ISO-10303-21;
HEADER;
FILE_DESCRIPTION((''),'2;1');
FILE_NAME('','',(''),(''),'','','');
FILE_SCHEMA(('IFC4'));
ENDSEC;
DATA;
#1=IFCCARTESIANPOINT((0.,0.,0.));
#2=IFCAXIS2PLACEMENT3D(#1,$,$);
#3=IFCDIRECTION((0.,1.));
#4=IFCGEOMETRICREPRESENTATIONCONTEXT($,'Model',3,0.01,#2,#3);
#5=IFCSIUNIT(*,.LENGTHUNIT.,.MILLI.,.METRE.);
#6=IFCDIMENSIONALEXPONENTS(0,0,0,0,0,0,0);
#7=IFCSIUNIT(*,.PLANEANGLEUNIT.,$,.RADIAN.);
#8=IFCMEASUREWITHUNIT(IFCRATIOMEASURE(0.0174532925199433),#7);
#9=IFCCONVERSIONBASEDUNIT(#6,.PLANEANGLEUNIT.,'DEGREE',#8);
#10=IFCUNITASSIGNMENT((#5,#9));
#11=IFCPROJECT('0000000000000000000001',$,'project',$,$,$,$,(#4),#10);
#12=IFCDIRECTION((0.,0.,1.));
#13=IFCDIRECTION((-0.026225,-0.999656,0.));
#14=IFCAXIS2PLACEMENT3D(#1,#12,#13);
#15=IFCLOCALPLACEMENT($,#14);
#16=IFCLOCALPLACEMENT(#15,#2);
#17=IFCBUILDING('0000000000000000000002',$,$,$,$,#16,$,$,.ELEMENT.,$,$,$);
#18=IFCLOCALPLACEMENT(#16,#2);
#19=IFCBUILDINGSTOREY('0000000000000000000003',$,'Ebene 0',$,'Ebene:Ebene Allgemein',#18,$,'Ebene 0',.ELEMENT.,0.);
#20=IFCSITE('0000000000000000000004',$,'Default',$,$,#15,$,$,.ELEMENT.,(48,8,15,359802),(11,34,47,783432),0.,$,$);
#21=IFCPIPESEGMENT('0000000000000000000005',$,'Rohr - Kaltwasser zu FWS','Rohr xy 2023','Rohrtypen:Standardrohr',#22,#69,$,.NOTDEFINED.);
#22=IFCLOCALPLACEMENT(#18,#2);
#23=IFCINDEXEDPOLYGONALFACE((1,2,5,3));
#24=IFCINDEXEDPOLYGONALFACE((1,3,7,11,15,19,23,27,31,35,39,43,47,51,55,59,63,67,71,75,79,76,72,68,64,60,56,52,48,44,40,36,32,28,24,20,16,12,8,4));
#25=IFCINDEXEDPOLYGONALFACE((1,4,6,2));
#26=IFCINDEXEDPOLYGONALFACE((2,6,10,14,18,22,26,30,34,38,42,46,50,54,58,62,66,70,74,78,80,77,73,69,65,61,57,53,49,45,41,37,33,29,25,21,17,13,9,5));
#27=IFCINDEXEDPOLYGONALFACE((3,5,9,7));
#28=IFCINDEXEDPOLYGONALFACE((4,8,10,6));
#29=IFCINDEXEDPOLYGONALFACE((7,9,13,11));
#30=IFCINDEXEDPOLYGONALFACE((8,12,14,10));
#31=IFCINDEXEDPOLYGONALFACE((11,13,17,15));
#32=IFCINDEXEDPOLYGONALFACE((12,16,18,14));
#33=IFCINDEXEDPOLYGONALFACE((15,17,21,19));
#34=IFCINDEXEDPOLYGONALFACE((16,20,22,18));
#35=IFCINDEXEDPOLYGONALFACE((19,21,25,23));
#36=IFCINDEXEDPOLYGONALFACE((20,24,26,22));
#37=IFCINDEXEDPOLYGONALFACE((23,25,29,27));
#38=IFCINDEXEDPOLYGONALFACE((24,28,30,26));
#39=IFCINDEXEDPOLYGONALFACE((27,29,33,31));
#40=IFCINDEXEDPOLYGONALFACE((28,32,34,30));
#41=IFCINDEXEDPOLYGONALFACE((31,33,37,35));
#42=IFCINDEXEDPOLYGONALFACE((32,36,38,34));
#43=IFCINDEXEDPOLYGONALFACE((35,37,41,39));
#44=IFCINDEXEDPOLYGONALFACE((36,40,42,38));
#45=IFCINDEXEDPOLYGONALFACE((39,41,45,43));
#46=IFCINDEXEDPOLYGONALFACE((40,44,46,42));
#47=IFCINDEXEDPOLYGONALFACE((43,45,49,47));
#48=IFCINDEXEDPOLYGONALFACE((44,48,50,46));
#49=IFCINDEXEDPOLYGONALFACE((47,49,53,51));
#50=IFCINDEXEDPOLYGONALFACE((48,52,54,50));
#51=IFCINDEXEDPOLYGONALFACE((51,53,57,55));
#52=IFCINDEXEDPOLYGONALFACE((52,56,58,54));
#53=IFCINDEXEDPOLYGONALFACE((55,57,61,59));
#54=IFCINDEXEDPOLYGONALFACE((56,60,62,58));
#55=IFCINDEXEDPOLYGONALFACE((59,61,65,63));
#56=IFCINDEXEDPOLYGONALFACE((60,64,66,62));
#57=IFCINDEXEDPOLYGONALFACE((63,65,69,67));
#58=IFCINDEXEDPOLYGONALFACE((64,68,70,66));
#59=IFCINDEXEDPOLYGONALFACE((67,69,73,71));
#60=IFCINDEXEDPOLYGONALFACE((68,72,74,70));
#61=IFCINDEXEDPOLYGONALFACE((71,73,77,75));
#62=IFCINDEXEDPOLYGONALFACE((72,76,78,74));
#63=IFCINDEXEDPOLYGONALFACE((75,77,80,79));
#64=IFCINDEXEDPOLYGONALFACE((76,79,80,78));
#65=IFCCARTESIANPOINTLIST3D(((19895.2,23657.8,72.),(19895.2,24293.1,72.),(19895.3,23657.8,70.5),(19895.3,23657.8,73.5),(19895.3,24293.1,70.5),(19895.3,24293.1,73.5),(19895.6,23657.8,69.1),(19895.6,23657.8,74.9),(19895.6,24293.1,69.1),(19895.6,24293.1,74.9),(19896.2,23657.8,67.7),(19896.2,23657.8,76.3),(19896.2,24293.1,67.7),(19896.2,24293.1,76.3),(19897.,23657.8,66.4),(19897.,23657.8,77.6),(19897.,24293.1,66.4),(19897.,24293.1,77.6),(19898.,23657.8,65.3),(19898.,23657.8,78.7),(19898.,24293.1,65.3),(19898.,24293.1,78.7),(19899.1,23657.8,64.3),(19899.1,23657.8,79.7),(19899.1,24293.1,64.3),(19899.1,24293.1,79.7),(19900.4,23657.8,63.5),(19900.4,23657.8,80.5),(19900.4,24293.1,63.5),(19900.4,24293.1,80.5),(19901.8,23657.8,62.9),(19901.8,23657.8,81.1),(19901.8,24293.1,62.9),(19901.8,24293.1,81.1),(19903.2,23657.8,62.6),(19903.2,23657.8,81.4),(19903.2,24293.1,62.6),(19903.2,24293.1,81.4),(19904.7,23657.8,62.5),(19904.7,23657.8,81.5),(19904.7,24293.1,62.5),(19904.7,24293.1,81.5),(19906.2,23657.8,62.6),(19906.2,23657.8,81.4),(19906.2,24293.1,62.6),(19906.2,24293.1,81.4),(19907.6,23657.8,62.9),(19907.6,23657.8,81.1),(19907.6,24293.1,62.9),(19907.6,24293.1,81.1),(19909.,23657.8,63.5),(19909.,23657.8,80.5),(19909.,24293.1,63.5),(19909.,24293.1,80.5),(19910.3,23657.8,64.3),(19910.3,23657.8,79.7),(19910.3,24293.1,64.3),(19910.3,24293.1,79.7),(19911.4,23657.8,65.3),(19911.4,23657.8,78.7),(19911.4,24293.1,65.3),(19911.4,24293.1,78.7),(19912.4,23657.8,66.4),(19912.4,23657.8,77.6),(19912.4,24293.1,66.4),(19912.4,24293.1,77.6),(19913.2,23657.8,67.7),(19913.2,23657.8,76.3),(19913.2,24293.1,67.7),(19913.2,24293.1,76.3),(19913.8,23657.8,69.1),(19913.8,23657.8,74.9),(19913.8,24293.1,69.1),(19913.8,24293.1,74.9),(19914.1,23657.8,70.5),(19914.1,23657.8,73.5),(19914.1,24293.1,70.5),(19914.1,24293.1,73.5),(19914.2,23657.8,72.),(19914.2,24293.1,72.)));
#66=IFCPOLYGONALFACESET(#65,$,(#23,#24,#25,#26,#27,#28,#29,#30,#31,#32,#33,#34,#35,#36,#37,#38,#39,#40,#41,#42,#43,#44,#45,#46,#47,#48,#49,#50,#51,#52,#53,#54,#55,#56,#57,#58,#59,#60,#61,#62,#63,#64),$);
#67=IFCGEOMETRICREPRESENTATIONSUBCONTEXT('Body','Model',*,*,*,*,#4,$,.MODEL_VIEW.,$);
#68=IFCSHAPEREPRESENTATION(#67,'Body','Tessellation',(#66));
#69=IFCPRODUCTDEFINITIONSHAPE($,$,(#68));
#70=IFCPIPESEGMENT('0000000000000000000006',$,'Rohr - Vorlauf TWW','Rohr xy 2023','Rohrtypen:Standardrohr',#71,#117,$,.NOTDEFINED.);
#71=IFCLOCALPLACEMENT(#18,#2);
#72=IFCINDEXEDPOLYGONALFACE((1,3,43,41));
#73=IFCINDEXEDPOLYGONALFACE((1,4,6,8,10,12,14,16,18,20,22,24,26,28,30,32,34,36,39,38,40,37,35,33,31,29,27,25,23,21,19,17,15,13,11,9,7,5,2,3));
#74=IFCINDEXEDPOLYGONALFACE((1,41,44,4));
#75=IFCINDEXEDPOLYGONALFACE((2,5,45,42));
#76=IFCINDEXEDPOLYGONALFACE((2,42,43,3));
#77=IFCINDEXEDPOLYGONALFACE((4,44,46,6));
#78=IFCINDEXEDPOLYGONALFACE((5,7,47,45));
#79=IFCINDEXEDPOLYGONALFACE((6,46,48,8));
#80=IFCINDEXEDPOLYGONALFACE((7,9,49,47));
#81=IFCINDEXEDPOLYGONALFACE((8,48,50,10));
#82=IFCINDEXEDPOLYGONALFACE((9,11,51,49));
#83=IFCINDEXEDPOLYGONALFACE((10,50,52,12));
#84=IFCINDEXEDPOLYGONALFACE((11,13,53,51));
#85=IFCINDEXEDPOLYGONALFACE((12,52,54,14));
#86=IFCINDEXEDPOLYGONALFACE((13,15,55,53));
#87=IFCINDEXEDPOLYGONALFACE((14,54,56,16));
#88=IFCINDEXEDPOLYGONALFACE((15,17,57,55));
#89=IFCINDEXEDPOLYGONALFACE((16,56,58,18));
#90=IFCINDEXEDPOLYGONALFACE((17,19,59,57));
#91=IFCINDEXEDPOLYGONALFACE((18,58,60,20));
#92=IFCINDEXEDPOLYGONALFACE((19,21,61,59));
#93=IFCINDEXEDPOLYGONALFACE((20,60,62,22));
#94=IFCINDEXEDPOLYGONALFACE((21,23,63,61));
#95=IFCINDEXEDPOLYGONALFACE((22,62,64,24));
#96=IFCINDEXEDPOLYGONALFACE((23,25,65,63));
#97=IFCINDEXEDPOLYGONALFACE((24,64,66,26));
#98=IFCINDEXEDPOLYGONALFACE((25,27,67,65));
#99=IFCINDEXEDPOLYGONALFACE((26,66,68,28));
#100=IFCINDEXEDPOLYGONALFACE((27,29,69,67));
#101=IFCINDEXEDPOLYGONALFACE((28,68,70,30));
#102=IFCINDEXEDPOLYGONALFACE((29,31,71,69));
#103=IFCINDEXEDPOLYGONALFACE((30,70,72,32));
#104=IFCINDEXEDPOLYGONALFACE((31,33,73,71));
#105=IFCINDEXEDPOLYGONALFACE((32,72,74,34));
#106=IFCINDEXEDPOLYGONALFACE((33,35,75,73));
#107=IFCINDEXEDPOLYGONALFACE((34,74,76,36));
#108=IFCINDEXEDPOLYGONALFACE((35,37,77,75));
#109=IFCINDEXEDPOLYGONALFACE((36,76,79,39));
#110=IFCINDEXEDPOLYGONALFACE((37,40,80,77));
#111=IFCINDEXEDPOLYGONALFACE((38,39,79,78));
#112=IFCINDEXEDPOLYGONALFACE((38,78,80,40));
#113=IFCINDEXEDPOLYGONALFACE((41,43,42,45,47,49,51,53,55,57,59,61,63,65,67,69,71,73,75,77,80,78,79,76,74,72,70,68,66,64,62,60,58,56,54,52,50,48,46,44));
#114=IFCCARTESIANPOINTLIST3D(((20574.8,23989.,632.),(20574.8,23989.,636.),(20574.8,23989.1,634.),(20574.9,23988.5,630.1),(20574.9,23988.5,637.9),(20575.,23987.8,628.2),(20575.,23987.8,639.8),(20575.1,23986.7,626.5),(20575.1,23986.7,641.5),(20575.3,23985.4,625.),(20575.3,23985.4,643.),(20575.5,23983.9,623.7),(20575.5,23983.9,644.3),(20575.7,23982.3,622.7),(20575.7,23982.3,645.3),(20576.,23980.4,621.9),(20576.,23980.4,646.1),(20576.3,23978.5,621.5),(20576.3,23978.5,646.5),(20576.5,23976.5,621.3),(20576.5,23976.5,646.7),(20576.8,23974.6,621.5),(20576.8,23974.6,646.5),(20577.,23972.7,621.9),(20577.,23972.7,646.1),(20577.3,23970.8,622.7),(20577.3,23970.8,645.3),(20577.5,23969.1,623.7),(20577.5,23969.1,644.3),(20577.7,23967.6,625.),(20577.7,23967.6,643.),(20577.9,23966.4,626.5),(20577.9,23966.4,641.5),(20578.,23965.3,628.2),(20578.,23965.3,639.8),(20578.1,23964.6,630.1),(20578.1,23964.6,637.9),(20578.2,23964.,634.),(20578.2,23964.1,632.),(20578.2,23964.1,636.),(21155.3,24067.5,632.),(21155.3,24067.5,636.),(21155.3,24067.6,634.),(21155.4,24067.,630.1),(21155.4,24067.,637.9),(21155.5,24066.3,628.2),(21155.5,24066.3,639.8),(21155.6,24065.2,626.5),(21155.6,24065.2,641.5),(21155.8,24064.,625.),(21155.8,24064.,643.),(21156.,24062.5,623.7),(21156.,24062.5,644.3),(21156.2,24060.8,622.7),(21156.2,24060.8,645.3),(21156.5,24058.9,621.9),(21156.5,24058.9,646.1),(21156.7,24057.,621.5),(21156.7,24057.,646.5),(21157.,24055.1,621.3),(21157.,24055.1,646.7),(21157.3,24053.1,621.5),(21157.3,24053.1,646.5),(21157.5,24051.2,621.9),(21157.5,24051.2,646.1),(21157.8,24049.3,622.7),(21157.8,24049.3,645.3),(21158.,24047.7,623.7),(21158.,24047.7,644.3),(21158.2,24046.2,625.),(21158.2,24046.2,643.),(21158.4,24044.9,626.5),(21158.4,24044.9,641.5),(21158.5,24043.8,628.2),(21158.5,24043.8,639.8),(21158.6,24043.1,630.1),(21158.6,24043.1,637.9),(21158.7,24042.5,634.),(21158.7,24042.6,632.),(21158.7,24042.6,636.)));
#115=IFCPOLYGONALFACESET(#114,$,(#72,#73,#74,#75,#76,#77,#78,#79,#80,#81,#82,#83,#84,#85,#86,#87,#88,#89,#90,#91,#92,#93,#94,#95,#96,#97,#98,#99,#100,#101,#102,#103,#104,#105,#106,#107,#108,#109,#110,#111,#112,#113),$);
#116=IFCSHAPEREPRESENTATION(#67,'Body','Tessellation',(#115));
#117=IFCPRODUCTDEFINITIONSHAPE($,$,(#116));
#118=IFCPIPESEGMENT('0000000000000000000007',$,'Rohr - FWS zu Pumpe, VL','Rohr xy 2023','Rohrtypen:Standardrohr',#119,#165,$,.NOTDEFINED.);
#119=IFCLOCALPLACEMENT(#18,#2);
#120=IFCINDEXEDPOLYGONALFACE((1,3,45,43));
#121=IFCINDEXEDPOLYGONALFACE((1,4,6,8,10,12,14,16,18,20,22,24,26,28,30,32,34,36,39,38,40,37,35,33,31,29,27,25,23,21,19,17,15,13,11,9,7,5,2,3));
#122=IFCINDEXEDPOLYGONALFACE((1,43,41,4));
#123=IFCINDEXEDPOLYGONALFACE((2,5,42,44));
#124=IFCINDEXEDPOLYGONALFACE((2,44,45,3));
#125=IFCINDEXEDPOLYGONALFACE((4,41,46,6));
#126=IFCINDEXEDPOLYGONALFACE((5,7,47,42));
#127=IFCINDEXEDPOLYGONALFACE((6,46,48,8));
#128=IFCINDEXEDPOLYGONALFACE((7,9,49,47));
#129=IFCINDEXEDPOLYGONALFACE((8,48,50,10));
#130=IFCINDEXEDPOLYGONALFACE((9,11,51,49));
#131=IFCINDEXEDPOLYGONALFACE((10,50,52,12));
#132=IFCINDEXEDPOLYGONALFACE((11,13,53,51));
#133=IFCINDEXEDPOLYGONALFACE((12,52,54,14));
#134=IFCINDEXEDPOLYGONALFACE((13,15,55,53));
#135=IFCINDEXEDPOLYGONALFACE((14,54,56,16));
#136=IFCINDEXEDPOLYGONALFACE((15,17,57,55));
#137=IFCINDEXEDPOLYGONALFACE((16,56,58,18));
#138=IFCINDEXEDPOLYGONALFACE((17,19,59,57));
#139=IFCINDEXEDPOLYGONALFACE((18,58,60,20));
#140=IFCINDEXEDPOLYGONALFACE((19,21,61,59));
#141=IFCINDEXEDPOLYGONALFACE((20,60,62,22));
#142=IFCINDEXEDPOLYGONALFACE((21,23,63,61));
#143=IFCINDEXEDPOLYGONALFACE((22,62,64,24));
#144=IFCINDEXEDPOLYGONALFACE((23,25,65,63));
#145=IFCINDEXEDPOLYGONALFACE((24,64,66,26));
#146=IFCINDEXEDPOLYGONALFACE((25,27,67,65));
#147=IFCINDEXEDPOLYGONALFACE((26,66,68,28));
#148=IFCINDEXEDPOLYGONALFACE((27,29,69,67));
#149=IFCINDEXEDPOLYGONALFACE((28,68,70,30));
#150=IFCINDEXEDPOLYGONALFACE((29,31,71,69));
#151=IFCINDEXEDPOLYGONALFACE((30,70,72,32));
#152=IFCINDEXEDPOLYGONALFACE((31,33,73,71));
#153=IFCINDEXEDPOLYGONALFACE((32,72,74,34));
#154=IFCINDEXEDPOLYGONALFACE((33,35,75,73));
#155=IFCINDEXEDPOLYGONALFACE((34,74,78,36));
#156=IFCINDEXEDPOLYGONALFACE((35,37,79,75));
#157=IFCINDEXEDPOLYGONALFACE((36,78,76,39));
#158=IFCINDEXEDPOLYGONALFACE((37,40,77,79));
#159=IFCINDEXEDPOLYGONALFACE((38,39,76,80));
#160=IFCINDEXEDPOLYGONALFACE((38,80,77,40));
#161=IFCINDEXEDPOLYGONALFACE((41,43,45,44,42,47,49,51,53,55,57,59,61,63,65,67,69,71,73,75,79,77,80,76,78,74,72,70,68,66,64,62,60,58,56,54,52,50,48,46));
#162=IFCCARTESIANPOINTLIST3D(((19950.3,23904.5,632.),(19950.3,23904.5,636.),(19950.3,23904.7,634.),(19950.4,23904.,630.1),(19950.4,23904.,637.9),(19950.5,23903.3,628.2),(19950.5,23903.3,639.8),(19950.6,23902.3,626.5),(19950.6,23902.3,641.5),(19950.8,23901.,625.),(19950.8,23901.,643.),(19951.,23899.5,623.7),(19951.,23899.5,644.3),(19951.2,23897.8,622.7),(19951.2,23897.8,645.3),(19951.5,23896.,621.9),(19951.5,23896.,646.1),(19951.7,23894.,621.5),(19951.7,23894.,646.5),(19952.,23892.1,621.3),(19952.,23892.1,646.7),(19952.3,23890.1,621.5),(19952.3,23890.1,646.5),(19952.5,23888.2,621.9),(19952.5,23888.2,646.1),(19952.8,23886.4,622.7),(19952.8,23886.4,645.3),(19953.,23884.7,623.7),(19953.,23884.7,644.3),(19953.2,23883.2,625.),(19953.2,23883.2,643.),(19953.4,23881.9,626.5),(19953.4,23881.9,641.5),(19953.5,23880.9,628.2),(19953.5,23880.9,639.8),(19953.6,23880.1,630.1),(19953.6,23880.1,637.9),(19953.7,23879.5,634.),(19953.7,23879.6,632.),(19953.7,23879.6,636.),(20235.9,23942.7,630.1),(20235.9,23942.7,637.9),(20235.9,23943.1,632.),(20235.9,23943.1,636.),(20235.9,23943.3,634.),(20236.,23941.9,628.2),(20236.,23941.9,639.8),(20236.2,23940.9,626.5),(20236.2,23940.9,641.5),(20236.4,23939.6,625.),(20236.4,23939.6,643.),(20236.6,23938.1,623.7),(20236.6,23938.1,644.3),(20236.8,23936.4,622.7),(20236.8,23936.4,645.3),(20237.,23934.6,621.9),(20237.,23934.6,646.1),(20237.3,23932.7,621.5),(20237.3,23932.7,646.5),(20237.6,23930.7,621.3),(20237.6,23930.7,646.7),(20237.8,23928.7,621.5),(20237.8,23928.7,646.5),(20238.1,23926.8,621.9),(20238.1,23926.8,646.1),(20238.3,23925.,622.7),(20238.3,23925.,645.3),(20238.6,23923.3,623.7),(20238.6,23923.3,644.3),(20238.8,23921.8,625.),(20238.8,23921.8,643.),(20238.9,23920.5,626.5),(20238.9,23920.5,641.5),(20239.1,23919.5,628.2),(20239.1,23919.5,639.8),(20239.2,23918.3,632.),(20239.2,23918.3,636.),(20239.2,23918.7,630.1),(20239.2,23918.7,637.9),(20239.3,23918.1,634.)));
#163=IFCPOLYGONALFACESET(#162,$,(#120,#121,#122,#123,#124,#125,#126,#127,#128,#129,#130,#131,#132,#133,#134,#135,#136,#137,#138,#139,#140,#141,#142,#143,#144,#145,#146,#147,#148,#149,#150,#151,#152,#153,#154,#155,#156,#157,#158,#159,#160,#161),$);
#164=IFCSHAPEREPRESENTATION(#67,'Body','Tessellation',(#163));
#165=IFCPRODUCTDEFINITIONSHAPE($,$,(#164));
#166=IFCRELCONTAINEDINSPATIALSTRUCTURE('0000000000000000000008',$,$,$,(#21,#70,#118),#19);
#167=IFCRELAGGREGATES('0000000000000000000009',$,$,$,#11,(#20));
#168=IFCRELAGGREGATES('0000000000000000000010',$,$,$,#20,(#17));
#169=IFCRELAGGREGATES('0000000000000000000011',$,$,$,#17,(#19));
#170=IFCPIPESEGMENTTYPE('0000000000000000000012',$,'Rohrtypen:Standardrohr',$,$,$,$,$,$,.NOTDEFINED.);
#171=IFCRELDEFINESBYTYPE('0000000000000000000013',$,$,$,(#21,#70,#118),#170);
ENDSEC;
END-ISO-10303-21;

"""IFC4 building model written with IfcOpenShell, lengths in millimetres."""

from ifc_helpers import new_model, entity, si_unit, converted_unit, direction, frame, origin, place, context, subcontext, project, spatial, indexed_curve, outline, extrude, type_object, element, save


model = new_model("IFC4")

# Units and contexts
model_context = context("Model", 3, precision=0.01, world=origin(), true_north=direction((0.0, 1.0)))
body_context = subcontext(model_context, "Body", "Model", "MODEL_VIEW")
ifc_project = project(units=[si_unit("LENGTHUNIT", "METRE", prefix="MILLI"), converted_unit("PLANEANGLEUNIT", "DEGREE", entity("IfcRatioMeasure", 0.0174532925199433), si_unit("PLANEANGLEUNIT", "RADIAN"), dimensions=[0, 0, 0, 0, 0, 0, 0])], contexts=[model_context])

# Site, building, storey
site_placement = place(None, frame((0.0, 0.0, 0.0), z_axis=(0.0, 0.0, 1.0), x_axis=(-0.026225, -0.999656, 0.0)))
site = spatial("IfcSite", under=ifc_project, at=site_placement, Name="Default", CompositionType="ELEMENT", RefLatitude=(48, 8, 15, 359802), RefLongitude=(11, 34, 47, 783432), RefElevation=0.0)
building_placement = place(site_placement, origin())
building = spatial("IfcBuilding", under=site, at=building_placement, CompositionType="ELEMENT")
storey_placement = place(building_placement, origin())
storey = spatial("IfcBuildingStorey", under=building, at=storey_placement, Name="Ebene 0", ObjectType="Ebene:Ebene Allgemein", LongName="Ebene 0", CompositionType="ELEMENT", Elevation=0.0)

# Pipe segments
pipe_segment_type = type_object("IfcPipeSegmentType", Name="Rohrtypen:Standardrohr", PredefinedType="NOTDEFINED")
pipe_segment_1_placement = place(storey_placement, origin())
element("IfcPipeSegment", 1, at=pipe_segment_1_placement, inside=storey, type_object=pipe_segment_type, Name="Rohr - Kaltwasser zu FWS", Description="Rohr xy 2023", ObjectType="Rohrtypen:Standardrohr", PredefinedType="NOTDEFINED", context=body_context, shape_type="SweptSolid", body=[
    extrude(outline(indexed_curve([(9.5, 0.0), (9.4, 1.5), (9.1, 2.9), (8.5, 4.3), (7.7, 5.6), (6.7, 6.7), (5.6, 7.7), (4.3, 8.5), (2.9, 9.1), (1.5, 9.4), (0.0, 9.5), (-1.5, 9.4), (-2.9, 9.1), (-4.3, 8.5), (-5.6, 7.7), (-6.7, 6.7), (-7.7, 5.6), (-8.5, 4.3), (-9.1, 2.9), (-9.4, 1.5), (-9.5, 0.0), (-9.4, -1.5), (-9.1, -2.9), (-8.5, -4.3), (-7.7, -5.6), (-6.7, -6.7), (-5.6, -7.7), (-4.3, -8.5), (-2.9, -9.1), (-1.5, -9.4), (0.0, -9.5), (1.5, -9.4), (2.9, -9.1), (4.3, -8.5), (5.6, -7.7), (6.7, -6.7), (7.7, -5.6), (8.5, -4.3), (9.1, -2.9), (9.4, -1.5), (9.5, 0.0)], self_intersect=False)), frame((19904.7, 23657.8, 72.0), z_axis=(0.0, 1.0, 0.0), x_axis=(1.0, 0.0, 0.0)), (0.0, 0.0, 1.0), 635.3),
])
pipe_segment_2_placement = place(storey_placement, origin())
element("IfcPipeSegment", 2, at=pipe_segment_2_placement, inside=storey, type_object=pipe_segment_type, Name="Rohr - Vorlauf TWW", Description="Rohr xy 2023", ObjectType="Rohrtypen:Standardrohr", PredefinedType="NOTDEFINED", context=body_context, shape_type="SweptSolid", body=[
    extrude(outline(indexed_curve([(12.7, 0.0), (12.5, 2.0), (12.1, 3.9), (11.3, 5.8), (10.3, 7.5), (9.0, 9.0), (7.5, 10.3), (5.8, 11.3), (3.9, 12.1), (2.0, 12.5), (0.0, 12.7), (-2.0, 12.5), (-3.9, 12.1), (-5.8, 11.3), (-7.5, 10.3), (-9.0, 9.0), (-10.3, 7.5), (-11.3, 5.8), (-12.1, 3.9), (-12.5, 2.0), (-12.7, 0.0), (-12.5, -2.0), (-12.1, -3.9), (-11.3, -5.8), (-10.3, -7.5), (-9.0, -9.0), (-7.5, -10.3), (-5.8, -11.3), (-3.9, -12.1), (-2.0, -12.5), (0.0, -12.7), (2.0, -12.5), (3.9, -12.1), (5.8, -11.3), (7.5, -10.3), (9.0, -9.0), (10.3, -7.5), (11.3, -5.8), (12.1, -3.9), (12.5, -2.0), (12.7, 0.0)], self_intersect=False)), frame((20576.5, 23976.5, 634.0), z_axis=(0.990977, 0.134035, 0.0), x_axis=(0.134035, -0.990977, 0.0)), (0.0, 0.0, 1.0), 585.8),
])
pipe_segment_3_placement = place(storey_placement, origin())
element("IfcPipeSegment", 3, at=pipe_segment_3_placement, inside=storey, type_object=pipe_segment_type, Name="Rohr - FWS zu Pumpe, VL", Description="Rohr xy 2023", ObjectType="Rohrtypen:Standardrohr", PredefinedType="NOTDEFINED", context=body_context, shape_type="SweptSolid", body=[
    extrude(outline(indexed_curve([(12.7, 0.0), (12.5, 2.0), (12.1, 3.9), (11.3, 5.8), (10.3, 7.5), (9.0, 9.0), (7.5, 10.3), (5.8, 11.3), (3.9, 12.1), (2.0, 12.5), (0.0, 12.7), (-2.0, 12.5), (-3.9, 12.1), (-5.8, 11.3), (-7.5, 10.3), (-9.0, 9.0), (-10.3, 7.5), (-11.3, 5.8), (-12.1, 3.9), (-12.5, 2.0), (-12.7, 0.0), (-12.5, -2.0), (-12.1, -3.9), (-11.3, -5.8), (-10.3, -7.5), (-9.0, -9.0), (-7.5, -10.3), (-5.8, -11.3), (-3.9, -12.1), (-2.0, -12.5), (0.0, -12.7), (2.0, -12.5), (3.9, -12.1), (5.8, -11.3), (7.5, -10.3), (9.0, -9.0), (10.3, -7.5), (11.3, -5.8), (12.1, -3.9), (12.5, -2.0), (12.7, 0.0)], self_intersect=False)), frame((19952.0, 23892.1, 634.0), z_axis=(0.990977, 0.134035, 0.0), x_axis=(0.134035, -0.990977, 0.0)), (0.0, 0.0, 1.0), 288.2),
])

save(model, "model.ifc")
